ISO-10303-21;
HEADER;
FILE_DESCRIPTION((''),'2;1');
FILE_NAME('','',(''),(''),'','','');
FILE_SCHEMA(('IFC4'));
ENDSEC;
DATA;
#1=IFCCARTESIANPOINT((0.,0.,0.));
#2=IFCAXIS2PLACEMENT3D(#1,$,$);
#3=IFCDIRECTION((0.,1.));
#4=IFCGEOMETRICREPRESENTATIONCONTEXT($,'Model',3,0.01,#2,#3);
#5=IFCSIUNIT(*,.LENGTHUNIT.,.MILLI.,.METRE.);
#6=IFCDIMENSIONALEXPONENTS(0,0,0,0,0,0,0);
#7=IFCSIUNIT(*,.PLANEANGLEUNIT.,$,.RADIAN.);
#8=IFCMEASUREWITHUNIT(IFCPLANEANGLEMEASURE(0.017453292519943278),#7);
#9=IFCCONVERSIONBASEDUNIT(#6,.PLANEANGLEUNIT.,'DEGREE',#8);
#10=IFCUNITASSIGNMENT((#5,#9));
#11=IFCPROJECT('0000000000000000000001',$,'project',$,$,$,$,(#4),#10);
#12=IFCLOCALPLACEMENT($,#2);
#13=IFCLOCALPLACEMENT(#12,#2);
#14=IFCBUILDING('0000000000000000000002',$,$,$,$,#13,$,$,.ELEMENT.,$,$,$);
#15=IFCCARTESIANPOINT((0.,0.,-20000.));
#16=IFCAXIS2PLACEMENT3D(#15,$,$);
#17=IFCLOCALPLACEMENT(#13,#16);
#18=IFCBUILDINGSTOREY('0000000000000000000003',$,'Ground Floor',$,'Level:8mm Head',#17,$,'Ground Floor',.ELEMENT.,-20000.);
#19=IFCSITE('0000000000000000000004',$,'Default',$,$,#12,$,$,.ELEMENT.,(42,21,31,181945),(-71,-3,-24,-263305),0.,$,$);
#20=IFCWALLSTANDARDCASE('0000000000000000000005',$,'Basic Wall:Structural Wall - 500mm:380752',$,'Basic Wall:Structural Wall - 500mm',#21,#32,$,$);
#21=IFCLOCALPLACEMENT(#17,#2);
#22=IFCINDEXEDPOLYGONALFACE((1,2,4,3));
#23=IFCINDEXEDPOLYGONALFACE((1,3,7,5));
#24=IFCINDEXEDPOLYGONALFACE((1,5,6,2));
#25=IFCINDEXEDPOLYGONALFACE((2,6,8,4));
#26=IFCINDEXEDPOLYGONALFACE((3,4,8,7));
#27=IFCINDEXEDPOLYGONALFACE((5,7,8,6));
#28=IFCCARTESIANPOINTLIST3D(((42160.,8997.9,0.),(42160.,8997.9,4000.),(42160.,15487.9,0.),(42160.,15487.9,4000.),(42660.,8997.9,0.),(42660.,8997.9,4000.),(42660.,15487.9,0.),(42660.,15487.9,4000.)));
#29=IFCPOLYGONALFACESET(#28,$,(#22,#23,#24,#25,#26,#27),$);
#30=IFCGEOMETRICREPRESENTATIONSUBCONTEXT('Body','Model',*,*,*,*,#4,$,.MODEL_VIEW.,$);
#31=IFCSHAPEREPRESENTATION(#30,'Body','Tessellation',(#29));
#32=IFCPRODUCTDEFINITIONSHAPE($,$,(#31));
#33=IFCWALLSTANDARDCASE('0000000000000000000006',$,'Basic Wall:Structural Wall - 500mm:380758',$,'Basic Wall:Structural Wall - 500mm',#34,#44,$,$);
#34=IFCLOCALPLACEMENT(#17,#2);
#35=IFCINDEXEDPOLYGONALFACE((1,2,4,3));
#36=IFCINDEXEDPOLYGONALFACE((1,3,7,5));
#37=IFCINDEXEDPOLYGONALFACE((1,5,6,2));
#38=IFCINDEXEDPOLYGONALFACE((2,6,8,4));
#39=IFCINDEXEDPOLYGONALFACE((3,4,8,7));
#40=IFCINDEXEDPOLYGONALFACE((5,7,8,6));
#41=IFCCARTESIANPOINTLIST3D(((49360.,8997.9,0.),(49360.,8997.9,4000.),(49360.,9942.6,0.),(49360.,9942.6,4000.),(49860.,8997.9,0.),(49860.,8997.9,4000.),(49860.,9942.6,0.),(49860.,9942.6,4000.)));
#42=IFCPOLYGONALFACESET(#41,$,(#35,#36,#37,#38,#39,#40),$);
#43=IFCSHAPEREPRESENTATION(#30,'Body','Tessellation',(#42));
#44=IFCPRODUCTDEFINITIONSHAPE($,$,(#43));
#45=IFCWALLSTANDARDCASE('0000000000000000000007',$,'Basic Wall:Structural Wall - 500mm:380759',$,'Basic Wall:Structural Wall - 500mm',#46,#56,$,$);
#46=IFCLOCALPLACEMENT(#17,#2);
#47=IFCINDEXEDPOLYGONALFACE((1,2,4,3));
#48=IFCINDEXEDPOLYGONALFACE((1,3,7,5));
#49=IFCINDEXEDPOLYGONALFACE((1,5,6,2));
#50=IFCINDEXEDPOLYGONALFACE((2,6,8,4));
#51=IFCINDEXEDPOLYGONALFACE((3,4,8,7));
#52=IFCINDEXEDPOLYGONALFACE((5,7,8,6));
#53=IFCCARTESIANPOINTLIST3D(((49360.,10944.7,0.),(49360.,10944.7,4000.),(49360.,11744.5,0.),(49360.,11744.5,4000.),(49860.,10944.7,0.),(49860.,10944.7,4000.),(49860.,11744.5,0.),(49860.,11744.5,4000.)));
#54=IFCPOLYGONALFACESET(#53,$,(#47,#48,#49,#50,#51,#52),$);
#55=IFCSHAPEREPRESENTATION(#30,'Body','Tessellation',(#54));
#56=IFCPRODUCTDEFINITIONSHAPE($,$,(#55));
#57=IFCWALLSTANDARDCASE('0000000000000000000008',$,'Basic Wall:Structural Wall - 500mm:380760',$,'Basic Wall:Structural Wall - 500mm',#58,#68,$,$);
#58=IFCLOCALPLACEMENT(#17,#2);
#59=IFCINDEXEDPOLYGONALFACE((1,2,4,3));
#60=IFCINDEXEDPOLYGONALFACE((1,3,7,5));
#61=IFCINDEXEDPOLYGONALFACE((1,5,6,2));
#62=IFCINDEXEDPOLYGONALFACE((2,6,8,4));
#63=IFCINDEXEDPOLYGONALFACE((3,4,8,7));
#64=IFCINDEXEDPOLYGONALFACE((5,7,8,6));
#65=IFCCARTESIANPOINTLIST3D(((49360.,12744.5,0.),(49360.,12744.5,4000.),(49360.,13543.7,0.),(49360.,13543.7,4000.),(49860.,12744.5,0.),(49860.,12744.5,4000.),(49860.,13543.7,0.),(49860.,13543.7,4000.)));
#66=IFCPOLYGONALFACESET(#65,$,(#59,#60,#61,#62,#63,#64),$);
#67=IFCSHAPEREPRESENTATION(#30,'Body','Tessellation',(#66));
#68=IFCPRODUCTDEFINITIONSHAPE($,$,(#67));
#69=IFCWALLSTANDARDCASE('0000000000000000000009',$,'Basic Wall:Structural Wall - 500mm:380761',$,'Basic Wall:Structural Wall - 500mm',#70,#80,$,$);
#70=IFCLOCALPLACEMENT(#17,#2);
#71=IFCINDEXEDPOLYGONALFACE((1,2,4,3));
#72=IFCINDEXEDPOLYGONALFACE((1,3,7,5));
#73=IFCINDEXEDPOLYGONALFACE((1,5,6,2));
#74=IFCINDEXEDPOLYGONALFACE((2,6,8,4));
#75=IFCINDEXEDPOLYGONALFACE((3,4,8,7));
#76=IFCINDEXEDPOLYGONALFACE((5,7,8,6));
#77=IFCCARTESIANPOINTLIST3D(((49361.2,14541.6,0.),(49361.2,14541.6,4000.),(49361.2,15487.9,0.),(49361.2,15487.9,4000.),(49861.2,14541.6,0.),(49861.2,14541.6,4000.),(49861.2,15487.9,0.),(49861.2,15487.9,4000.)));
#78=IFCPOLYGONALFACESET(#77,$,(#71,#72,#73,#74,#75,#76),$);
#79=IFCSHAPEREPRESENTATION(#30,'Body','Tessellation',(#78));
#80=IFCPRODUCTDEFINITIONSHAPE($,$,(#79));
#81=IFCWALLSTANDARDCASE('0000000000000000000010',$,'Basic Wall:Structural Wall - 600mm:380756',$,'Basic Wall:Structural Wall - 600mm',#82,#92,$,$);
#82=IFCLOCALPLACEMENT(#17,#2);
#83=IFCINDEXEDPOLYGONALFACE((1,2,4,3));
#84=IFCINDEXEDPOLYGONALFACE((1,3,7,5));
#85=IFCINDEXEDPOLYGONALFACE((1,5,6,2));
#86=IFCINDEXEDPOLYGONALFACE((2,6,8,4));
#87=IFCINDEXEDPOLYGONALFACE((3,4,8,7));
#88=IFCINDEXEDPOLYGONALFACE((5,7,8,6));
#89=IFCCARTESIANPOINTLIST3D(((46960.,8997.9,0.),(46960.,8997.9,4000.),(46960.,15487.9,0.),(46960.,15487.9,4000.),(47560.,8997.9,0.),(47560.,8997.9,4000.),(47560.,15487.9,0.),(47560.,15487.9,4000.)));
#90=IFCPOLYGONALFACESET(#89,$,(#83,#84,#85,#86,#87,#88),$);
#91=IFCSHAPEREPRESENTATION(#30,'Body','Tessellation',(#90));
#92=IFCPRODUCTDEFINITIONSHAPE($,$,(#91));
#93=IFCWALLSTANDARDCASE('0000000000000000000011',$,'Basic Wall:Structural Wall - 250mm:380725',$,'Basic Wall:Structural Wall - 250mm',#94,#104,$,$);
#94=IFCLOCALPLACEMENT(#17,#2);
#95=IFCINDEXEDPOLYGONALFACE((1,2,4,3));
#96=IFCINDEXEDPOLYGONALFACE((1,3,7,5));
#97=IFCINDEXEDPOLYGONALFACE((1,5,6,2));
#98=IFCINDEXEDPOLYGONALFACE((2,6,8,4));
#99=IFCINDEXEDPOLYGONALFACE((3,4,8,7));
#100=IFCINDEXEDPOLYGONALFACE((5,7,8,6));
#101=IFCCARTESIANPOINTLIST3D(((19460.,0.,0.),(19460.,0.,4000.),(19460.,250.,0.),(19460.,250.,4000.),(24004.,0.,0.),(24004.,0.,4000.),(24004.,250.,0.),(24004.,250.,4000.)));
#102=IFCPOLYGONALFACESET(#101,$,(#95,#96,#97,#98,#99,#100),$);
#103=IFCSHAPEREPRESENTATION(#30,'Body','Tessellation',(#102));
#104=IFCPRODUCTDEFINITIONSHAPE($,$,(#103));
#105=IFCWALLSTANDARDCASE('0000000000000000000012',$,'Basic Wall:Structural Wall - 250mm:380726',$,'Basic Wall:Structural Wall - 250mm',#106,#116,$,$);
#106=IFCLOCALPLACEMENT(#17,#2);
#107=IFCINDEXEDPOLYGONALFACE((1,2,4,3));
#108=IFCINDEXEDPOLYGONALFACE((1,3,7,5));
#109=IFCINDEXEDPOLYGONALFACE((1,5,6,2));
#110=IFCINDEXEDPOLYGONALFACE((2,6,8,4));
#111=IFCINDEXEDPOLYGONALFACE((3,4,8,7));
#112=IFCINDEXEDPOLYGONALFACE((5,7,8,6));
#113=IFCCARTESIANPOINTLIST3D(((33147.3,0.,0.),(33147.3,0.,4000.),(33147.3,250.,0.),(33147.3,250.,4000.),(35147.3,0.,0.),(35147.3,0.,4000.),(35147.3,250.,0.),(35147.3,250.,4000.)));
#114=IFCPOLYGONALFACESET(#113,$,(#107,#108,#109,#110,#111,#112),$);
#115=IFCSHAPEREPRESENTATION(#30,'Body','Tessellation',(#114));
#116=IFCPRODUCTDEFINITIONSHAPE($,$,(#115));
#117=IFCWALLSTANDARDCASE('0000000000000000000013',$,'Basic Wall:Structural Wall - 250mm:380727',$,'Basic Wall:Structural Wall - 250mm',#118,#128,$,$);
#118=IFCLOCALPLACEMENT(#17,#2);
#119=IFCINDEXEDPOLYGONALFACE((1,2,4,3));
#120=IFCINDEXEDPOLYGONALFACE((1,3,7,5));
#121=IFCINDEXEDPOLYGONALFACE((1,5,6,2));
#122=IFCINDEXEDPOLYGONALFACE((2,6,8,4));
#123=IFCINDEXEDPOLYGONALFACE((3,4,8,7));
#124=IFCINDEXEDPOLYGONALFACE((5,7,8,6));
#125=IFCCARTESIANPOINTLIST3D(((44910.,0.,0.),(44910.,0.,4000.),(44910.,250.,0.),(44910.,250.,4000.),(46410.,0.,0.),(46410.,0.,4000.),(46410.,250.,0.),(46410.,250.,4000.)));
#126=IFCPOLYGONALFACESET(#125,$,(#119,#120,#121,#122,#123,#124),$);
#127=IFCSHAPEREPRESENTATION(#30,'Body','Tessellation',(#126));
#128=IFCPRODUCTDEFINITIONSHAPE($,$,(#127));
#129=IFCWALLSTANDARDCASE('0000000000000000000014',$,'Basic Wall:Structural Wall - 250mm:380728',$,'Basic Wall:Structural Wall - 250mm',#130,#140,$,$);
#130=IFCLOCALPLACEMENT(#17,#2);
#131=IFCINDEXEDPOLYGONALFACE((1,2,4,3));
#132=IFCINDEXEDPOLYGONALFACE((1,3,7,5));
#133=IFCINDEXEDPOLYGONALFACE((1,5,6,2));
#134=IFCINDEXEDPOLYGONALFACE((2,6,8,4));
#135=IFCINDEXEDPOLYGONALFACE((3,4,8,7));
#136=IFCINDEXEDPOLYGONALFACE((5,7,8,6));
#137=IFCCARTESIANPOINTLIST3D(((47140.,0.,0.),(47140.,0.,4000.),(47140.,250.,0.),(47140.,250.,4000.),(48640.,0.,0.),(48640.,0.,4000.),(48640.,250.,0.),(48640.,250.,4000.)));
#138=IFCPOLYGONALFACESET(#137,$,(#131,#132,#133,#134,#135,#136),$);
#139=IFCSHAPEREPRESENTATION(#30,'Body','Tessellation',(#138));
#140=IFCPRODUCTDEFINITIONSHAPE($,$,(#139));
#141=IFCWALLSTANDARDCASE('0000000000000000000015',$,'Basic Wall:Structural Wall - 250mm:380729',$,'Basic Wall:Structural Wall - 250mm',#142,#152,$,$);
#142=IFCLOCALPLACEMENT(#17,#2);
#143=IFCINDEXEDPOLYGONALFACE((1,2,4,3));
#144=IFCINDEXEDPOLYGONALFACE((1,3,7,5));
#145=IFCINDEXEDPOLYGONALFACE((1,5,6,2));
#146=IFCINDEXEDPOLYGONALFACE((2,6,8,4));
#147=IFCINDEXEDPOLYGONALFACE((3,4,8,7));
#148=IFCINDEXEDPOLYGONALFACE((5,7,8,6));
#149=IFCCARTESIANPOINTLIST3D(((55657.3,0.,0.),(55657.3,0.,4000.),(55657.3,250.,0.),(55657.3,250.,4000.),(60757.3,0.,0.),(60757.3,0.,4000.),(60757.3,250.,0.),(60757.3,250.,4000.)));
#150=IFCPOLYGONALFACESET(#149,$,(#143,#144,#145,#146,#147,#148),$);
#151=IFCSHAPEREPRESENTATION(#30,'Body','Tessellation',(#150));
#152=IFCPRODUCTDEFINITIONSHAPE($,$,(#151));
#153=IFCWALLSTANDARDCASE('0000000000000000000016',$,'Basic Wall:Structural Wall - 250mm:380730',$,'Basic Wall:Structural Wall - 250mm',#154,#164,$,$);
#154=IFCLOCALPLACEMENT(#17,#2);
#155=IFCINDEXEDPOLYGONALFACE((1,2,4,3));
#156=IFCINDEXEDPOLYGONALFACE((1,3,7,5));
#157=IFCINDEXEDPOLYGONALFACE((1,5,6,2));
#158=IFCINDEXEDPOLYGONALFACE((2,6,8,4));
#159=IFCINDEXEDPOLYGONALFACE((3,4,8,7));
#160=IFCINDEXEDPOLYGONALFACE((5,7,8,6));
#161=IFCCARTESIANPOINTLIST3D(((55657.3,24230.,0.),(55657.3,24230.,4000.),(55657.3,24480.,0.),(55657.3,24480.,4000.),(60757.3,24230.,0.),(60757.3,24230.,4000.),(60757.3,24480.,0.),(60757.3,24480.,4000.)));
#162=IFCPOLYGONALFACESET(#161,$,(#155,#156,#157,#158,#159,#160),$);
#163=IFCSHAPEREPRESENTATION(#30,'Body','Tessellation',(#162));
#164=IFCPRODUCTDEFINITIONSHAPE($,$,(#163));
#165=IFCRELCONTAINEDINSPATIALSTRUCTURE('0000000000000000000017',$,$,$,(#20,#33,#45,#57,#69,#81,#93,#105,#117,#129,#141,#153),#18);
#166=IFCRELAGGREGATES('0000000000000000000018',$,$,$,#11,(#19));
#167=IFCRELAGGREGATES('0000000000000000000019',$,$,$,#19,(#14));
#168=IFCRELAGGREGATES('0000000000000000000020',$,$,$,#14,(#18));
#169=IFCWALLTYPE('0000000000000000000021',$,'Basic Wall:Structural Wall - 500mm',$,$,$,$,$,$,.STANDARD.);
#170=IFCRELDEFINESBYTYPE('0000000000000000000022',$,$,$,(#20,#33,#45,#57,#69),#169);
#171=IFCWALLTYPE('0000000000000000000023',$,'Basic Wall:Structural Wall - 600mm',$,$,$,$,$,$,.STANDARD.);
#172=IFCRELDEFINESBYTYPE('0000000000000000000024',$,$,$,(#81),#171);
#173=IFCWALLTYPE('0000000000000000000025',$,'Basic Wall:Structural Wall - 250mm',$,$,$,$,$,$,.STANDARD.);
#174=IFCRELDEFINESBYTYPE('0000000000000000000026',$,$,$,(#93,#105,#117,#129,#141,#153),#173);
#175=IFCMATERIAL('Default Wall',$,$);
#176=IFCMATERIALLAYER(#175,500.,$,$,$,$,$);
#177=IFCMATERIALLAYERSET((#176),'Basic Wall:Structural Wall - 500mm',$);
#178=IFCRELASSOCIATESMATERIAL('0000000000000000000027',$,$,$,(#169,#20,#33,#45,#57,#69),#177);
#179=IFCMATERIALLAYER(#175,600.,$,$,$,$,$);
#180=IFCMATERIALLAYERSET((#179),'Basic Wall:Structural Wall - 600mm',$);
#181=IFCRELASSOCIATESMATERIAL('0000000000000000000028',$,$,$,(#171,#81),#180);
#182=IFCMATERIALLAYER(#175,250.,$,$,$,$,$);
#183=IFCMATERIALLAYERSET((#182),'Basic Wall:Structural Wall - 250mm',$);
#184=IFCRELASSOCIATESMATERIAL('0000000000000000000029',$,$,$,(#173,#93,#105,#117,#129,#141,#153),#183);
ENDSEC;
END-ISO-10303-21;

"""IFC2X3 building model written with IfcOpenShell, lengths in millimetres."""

from ifc_helpers import new_model, entity, si_unit, converted_unit, direction, frame, frame_2d, origin, place, context, subcontext, project, spatial, rectangle, extrude, material, layer, layer_set, layer_usage, type_object, element, save


model = new_model("IFC2X3")

# Units and contexts
model_context = context("Model", 3, precision=0.01, world=origin(), true_north=direction((0.0, 1.0)))
body_context = subcontext(model_context, "Body", "Model", "MODEL_VIEW")
ifc_project = project(units=[si_unit("LENGTHUNIT", "METRE", prefix="MILLI"), converted_unit("PLANEANGLEUNIT", "DEGREE", entity("IfcPlaneAngleMeasure", 0.017453292519943278), si_unit("PLANEANGLEUNIT", "RADIAN"), dimensions=[0, 0, 0, 0, 0, 0, 0])], contexts=[model_context])

# Site, building, storey
site_placement = place(None, origin())
site = spatial("IfcSite", under=ifc_project, at=site_placement, Name="Default", CompositionType="ELEMENT", RefLatitude=(42, 21, 31, 181945), RefLongitude=(-71, -3, -24, -263305), RefElevation=0.0)
building_placement = place(site_placement, origin())
building = spatial("IfcBuilding", under=site, at=building_placement, CompositionType="ELEMENT")
storey_placement = place(building_placement, frame((0.0, 0.0, -20000.0)))
storey = spatial("IfcBuildingStorey", under=building, at=storey_placement, Name="Ground Floor", ObjectType="Level:8mm Head", LongName="Ground Floor", CompositionType="ELEMENT", Elevation=-20000.0)

# Walls
ifc_material_1 = material(Name="Default Wall")
ifc_layer_1 = layer(ifc_material_1, 500.0)
ifc_layer_set_1 = layer_set([ifc_layer_1], Name="Basic Wall:Structural Wall - 500mm")
wall_type_1 = type_object("IfcWallType", Name="Basic Wall:Structural Wall - 500mm", PredefinedType="STANDARD", material=ifc_layer_set_1)
ifc_layer_usage_1 = layer_usage(ifc_layer_set_1, "AXIS2", "NEGATIVE", 250.0)
wall_1_placement = place(storey_placement, frame((42410.0, 15487.9, 0.0), z_axis=(0.0, 0.0, 1.0), x_axis=(0.0, -1.0, 0.0)))
element("IfcWallStandardCase", 1, at=wall_1_placement, inside=storey, type_object=wall_type_1, material=ifc_layer_usage_1, Name="Basic Wall:Structural Wall - 500mm:380752", ObjectType="Basic Wall:Structural Wall - 500mm", context=body_context, shape_type="SweptSolid", body=[
    extrude(rectangle(XDim=6490.0, YDim=500.0, at=frame_2d((3245.0, 0.0), x_axis=(-1.0, 0.0))), origin(), (0.0, 0.0, 1.0), 4000.0),
])
ifc_layer_usage_2 = layer_usage(ifc_layer_set_1, "AXIS2", "NEGATIVE", 250.0)
wall_2_placement = place(storey_placement, frame((49610.0, 8997.9, 0.0), z_axis=(0.0, 0.0, 1.0), x_axis=(0.0, 1.0, 0.0)))
element("IfcWallStandardCase", 2, at=wall_2_placement, inside=storey, type_object=wall_type_1, material=ifc_layer_usage_2, Name="Basic Wall:Structural Wall - 500mm:380758", ObjectType="Basic Wall:Structural Wall - 500mm", context=body_context, shape_type="SweptSolid", body=[
    extrude(rectangle(XDim=944.7, YDim=500.0, at=frame_2d((472.3, 0.0), x_axis=(-1.0, 0.0))), origin(), (0.0, 0.0, 1.0), 4000.0),
])
ifc_layer_usage_3 = layer_usage(ifc_layer_set_1, "AXIS2", "NEGATIVE", 250.0)
wall_3_placement = place(storey_placement, frame((49610.0, 10944.7, 0.0), z_axis=(0.0, 0.0, 1.0), x_axis=(0.0, 1.0, 0.0)))
element("IfcWallStandardCase", 3, at=wall_3_placement, inside=storey, type_object=wall_type_1, material=ifc_layer_usage_3, Name="Basic Wall:Structural Wall - 500mm:380759", ObjectType="Basic Wall:Structural Wall - 500mm", context=body_context, shape_type="SweptSolid", body=[
    extrude(rectangle(XDim=799.8, YDim=500.0, at=frame_2d((399.9, 0.0), x_axis=(-1.0, 0.0))), origin(), (0.0, 0.0, 1.0), 4000.0),
])
ifc_layer_usage_4 = layer_usage(ifc_layer_set_1, "AXIS2", "NEGATIVE", 250.0)
wall_4_placement = place(storey_placement, frame((49610.0, 12744.5, 0.0), z_axis=(0.0, 0.0, 1.0), x_axis=(0.0, 1.0, 0.0)))
element("IfcWallStandardCase", 4, at=wall_4_placement, inside=storey, type_object=wall_type_1, material=ifc_layer_usage_4, Name="Basic Wall:Structural Wall - 500mm:380760", ObjectType="Basic Wall:Structural Wall - 500mm", context=body_context, shape_type="SweptSolid", body=[
    extrude(rectangle(XDim=799.2, YDim=500.0, at=frame_2d((399.6, 0.0), x_axis=(-1.0, 0.0))), origin(), (0.0, 0.0, 1.0), 4000.0),
])
ifc_layer_usage_5 = layer_usage(ifc_layer_set_1, "AXIS2", "NEGATIVE", 250.0)
wall_5_placement = place(storey_placement, frame((49611.2, 14541.6, 0.0), z_axis=(0.0, 0.0, 1.0), x_axis=(0.0, 1.0, 0.0)))
element("IfcWallStandardCase", 5, at=wall_5_placement, inside=storey, type_object=wall_type_1, material=ifc_layer_usage_5, Name="Basic Wall:Structural Wall - 500mm:380761", ObjectType="Basic Wall:Structural Wall - 500mm", context=body_context, shape_type="SweptSolid", body=[
    extrude(rectangle(XDim=946.3, YDim=500.0, at=frame_2d((473.2, 0.0), x_axis=(-1.0, 0.0))), origin(), (0.0, 0.0, 1.0), 4000.0),
])
ifc_layer_2 = layer(ifc_material_1, 600.0)
ifc_layer_set_2 = layer_set([ifc_layer_2], Name="Basic Wall:Structural Wall - 600mm")
ifc_layer_usage_6 = layer_usage(ifc_layer_set_2, "AXIS2", "NEGATIVE", 300.0)
wall_type_2 = type_object("IfcWallType", Name="Basic Wall:Structural Wall - 600mm", PredefinedType="STANDARD", material=ifc_layer_set_2)
wall_6_placement = place(storey_placement, frame((47260.0, 15487.9, 0.0), z_axis=(0.0, 0.0, 1.0), x_axis=(0.0, -1.0, 0.0)))
element("IfcWallStandardCase", 6, at=wall_6_placement, inside=storey, type_object=wall_type_2, material=ifc_layer_usage_6, Name="Basic Wall:Structural Wall - 600mm:380756", ObjectType="Basic Wall:Structural Wall - 600mm", context=body_context, shape_type="SweptSolid", body=[
    extrude(rectangle(XDim=6490.0, YDim=600.0, at=frame_2d((3245.0, 0.0), x_axis=(-1.0, 0.0))), origin(), (0.0, 0.0, 1.0), 4000.0),
])
ifc_layer_3 = layer(ifc_material_1, 250.0)
ifc_layer_set_3 = layer_set([ifc_layer_3], Name="Basic Wall:Structural Wall - 250mm")
ifc_layer_usage_7 = layer_usage(ifc_layer_set_3, "AXIS2", "NEGATIVE", 125.0)
wall_type_3 = type_object("IfcWallType", Name="Basic Wall:Structural Wall - 250mm", PredefinedType="STANDARD", material=ifc_layer_set_3)
wall_7_placement = place(storey_placement, frame((24004.0, 125.0, 0.0), z_axis=(0.0, 0.0, 1.0), x_axis=(-1.0, 0.0, 0.0)))
element("IfcWallStandardCase", 7, at=wall_7_placement, inside=storey, type_object=wall_type_3, material=ifc_layer_usage_7, Name="Basic Wall:Structural Wall - 250mm:380725", ObjectType="Basic Wall:Structural Wall - 250mm", context=body_context, shape_type="SweptSolid", body=[
    extrude(rectangle(XDim=4544.0, YDim=250.0, at=frame_2d((2272.0, 0.0), x_axis=(-1.0, 0.0))), origin(), (0.0, 0.0, 1.0), 4000.0),
])
ifc_layer_usage_8 = layer_usage(ifc_layer_set_3, "AXIS2", "NEGATIVE", 125.0)
wall_8_placement = place(storey_placement, frame((35147.3, 125.0, 0.0), z_axis=(0.0, 0.0, 1.0), x_axis=(-1.0, 0.0, 0.0)))
element("IfcWallStandardCase", 8, at=wall_8_placement, inside=storey, type_object=wall_type_3, material=ifc_layer_usage_8, Name="Basic Wall:Structural Wall - 250mm:380726", ObjectType="Basic Wall:Structural Wall - 250mm", context=body_context, shape_type="SweptSolid", body=[
    extrude(rectangle(XDim=2000.0, YDim=250.0, at=frame_2d((1000.0, 0.0), x_axis=(-1.0, 0.0))), origin(), (0.0, 0.0, 1.0), 4000.0),
])
ifc_layer_usage_9 = layer_usage(ifc_layer_set_3, "AXIS2", "NEGATIVE", 125.0)
wall_9_placement = place(storey_placement, frame((46410.0, 125.0, 0.0), z_axis=(0.0, 0.0, 1.0), x_axis=(-1.0, 0.0, 0.0)))
element("IfcWallStandardCase", 9, at=wall_9_placement, inside=storey, type_object=wall_type_3, material=ifc_layer_usage_9, Name="Basic Wall:Structural Wall - 250mm:380727", ObjectType="Basic Wall:Structural Wall - 250mm", context=body_context, shape_type="SweptSolid", body=[
    extrude(rectangle(XDim=1500.0, YDim=250.0, at=frame_2d((750.0, 0.0), x_axis=(-1.0, 0.0))), origin(), (0.0, 0.0, 1.0), 4000.0),
])
ifc_layer_usage_10 = layer_usage(ifc_layer_set_3, "AXIS2", "NEGATIVE", 125.0)
wall_10_placement = place(storey_placement, frame((48640.0, 125.0, 0.0), z_axis=(0.0, 0.0, 1.0), x_axis=(-1.0, 0.0, 0.0)))
element("IfcWallStandardCase", 10, at=wall_10_placement, inside=storey, type_object=wall_type_3, material=ifc_layer_usage_10, Name="Basic Wall:Structural Wall - 250mm:380728", ObjectType="Basic Wall:Structural Wall - 250mm", context=body_context, shape_type="SweptSolid", body=[
    extrude(rectangle(XDim=1500.0, YDim=250.0, at=frame_2d((750.0, 0.0), x_axis=(-1.0, 0.0))), origin(), (0.0, 0.0, 1.0), 4000.0),
])
ifc_layer_usage_11 = layer_usage(ifc_layer_set_3, "AXIS2", "NEGATIVE", 125.0)
wall_11_placement = place(storey_placement, frame((60757.3, 125.0, 0.0), z_axis=(0.0, 0.0, 1.0), x_axis=(-1.0, 0.0, 0.0)))
element("IfcWallStandardCase", 11, at=wall_11_placement, inside=storey, type_object=wall_type_3, material=ifc_layer_usage_11, Name="Basic Wall:Structural Wall - 250mm:380729", ObjectType="Basic Wall:Structural Wall - 250mm", context=body_context, shape_type="SweptSolid", body=[
    extrude(rectangle(XDim=5100.0, YDim=250.0, at=frame_2d((2550.0, 0.0), x_axis=(-1.0, 0.0))), origin(), (0.0, 0.0, 1.0), 4000.0),
])
ifc_layer_usage_12 = layer_usage(ifc_layer_set_3, "AXIS2", "NEGATIVE", 125.0)
wall_12_placement = place(storey_placement, frame((55657.3, 24355.0, 0.0)))
element("IfcWallStandardCase", 12, at=wall_12_placement, inside=storey, type_object=wall_type_3, material=ifc_layer_usage_12, Name="Basic Wall:Structural Wall - 250mm:380730", ObjectType="Basic Wall:Structural Wall - 250mm", context=body_context, shape_type="SweptSolid", body=[
    extrude(rectangle(XDim=5100.0, YDim=250.0, at=frame_2d((2550.0, 0.0), x_axis=(-1.0, 0.0))), origin(), (0.0, 0.0, 1.0), 4000.0),
])

save(model, "model.ifc")
